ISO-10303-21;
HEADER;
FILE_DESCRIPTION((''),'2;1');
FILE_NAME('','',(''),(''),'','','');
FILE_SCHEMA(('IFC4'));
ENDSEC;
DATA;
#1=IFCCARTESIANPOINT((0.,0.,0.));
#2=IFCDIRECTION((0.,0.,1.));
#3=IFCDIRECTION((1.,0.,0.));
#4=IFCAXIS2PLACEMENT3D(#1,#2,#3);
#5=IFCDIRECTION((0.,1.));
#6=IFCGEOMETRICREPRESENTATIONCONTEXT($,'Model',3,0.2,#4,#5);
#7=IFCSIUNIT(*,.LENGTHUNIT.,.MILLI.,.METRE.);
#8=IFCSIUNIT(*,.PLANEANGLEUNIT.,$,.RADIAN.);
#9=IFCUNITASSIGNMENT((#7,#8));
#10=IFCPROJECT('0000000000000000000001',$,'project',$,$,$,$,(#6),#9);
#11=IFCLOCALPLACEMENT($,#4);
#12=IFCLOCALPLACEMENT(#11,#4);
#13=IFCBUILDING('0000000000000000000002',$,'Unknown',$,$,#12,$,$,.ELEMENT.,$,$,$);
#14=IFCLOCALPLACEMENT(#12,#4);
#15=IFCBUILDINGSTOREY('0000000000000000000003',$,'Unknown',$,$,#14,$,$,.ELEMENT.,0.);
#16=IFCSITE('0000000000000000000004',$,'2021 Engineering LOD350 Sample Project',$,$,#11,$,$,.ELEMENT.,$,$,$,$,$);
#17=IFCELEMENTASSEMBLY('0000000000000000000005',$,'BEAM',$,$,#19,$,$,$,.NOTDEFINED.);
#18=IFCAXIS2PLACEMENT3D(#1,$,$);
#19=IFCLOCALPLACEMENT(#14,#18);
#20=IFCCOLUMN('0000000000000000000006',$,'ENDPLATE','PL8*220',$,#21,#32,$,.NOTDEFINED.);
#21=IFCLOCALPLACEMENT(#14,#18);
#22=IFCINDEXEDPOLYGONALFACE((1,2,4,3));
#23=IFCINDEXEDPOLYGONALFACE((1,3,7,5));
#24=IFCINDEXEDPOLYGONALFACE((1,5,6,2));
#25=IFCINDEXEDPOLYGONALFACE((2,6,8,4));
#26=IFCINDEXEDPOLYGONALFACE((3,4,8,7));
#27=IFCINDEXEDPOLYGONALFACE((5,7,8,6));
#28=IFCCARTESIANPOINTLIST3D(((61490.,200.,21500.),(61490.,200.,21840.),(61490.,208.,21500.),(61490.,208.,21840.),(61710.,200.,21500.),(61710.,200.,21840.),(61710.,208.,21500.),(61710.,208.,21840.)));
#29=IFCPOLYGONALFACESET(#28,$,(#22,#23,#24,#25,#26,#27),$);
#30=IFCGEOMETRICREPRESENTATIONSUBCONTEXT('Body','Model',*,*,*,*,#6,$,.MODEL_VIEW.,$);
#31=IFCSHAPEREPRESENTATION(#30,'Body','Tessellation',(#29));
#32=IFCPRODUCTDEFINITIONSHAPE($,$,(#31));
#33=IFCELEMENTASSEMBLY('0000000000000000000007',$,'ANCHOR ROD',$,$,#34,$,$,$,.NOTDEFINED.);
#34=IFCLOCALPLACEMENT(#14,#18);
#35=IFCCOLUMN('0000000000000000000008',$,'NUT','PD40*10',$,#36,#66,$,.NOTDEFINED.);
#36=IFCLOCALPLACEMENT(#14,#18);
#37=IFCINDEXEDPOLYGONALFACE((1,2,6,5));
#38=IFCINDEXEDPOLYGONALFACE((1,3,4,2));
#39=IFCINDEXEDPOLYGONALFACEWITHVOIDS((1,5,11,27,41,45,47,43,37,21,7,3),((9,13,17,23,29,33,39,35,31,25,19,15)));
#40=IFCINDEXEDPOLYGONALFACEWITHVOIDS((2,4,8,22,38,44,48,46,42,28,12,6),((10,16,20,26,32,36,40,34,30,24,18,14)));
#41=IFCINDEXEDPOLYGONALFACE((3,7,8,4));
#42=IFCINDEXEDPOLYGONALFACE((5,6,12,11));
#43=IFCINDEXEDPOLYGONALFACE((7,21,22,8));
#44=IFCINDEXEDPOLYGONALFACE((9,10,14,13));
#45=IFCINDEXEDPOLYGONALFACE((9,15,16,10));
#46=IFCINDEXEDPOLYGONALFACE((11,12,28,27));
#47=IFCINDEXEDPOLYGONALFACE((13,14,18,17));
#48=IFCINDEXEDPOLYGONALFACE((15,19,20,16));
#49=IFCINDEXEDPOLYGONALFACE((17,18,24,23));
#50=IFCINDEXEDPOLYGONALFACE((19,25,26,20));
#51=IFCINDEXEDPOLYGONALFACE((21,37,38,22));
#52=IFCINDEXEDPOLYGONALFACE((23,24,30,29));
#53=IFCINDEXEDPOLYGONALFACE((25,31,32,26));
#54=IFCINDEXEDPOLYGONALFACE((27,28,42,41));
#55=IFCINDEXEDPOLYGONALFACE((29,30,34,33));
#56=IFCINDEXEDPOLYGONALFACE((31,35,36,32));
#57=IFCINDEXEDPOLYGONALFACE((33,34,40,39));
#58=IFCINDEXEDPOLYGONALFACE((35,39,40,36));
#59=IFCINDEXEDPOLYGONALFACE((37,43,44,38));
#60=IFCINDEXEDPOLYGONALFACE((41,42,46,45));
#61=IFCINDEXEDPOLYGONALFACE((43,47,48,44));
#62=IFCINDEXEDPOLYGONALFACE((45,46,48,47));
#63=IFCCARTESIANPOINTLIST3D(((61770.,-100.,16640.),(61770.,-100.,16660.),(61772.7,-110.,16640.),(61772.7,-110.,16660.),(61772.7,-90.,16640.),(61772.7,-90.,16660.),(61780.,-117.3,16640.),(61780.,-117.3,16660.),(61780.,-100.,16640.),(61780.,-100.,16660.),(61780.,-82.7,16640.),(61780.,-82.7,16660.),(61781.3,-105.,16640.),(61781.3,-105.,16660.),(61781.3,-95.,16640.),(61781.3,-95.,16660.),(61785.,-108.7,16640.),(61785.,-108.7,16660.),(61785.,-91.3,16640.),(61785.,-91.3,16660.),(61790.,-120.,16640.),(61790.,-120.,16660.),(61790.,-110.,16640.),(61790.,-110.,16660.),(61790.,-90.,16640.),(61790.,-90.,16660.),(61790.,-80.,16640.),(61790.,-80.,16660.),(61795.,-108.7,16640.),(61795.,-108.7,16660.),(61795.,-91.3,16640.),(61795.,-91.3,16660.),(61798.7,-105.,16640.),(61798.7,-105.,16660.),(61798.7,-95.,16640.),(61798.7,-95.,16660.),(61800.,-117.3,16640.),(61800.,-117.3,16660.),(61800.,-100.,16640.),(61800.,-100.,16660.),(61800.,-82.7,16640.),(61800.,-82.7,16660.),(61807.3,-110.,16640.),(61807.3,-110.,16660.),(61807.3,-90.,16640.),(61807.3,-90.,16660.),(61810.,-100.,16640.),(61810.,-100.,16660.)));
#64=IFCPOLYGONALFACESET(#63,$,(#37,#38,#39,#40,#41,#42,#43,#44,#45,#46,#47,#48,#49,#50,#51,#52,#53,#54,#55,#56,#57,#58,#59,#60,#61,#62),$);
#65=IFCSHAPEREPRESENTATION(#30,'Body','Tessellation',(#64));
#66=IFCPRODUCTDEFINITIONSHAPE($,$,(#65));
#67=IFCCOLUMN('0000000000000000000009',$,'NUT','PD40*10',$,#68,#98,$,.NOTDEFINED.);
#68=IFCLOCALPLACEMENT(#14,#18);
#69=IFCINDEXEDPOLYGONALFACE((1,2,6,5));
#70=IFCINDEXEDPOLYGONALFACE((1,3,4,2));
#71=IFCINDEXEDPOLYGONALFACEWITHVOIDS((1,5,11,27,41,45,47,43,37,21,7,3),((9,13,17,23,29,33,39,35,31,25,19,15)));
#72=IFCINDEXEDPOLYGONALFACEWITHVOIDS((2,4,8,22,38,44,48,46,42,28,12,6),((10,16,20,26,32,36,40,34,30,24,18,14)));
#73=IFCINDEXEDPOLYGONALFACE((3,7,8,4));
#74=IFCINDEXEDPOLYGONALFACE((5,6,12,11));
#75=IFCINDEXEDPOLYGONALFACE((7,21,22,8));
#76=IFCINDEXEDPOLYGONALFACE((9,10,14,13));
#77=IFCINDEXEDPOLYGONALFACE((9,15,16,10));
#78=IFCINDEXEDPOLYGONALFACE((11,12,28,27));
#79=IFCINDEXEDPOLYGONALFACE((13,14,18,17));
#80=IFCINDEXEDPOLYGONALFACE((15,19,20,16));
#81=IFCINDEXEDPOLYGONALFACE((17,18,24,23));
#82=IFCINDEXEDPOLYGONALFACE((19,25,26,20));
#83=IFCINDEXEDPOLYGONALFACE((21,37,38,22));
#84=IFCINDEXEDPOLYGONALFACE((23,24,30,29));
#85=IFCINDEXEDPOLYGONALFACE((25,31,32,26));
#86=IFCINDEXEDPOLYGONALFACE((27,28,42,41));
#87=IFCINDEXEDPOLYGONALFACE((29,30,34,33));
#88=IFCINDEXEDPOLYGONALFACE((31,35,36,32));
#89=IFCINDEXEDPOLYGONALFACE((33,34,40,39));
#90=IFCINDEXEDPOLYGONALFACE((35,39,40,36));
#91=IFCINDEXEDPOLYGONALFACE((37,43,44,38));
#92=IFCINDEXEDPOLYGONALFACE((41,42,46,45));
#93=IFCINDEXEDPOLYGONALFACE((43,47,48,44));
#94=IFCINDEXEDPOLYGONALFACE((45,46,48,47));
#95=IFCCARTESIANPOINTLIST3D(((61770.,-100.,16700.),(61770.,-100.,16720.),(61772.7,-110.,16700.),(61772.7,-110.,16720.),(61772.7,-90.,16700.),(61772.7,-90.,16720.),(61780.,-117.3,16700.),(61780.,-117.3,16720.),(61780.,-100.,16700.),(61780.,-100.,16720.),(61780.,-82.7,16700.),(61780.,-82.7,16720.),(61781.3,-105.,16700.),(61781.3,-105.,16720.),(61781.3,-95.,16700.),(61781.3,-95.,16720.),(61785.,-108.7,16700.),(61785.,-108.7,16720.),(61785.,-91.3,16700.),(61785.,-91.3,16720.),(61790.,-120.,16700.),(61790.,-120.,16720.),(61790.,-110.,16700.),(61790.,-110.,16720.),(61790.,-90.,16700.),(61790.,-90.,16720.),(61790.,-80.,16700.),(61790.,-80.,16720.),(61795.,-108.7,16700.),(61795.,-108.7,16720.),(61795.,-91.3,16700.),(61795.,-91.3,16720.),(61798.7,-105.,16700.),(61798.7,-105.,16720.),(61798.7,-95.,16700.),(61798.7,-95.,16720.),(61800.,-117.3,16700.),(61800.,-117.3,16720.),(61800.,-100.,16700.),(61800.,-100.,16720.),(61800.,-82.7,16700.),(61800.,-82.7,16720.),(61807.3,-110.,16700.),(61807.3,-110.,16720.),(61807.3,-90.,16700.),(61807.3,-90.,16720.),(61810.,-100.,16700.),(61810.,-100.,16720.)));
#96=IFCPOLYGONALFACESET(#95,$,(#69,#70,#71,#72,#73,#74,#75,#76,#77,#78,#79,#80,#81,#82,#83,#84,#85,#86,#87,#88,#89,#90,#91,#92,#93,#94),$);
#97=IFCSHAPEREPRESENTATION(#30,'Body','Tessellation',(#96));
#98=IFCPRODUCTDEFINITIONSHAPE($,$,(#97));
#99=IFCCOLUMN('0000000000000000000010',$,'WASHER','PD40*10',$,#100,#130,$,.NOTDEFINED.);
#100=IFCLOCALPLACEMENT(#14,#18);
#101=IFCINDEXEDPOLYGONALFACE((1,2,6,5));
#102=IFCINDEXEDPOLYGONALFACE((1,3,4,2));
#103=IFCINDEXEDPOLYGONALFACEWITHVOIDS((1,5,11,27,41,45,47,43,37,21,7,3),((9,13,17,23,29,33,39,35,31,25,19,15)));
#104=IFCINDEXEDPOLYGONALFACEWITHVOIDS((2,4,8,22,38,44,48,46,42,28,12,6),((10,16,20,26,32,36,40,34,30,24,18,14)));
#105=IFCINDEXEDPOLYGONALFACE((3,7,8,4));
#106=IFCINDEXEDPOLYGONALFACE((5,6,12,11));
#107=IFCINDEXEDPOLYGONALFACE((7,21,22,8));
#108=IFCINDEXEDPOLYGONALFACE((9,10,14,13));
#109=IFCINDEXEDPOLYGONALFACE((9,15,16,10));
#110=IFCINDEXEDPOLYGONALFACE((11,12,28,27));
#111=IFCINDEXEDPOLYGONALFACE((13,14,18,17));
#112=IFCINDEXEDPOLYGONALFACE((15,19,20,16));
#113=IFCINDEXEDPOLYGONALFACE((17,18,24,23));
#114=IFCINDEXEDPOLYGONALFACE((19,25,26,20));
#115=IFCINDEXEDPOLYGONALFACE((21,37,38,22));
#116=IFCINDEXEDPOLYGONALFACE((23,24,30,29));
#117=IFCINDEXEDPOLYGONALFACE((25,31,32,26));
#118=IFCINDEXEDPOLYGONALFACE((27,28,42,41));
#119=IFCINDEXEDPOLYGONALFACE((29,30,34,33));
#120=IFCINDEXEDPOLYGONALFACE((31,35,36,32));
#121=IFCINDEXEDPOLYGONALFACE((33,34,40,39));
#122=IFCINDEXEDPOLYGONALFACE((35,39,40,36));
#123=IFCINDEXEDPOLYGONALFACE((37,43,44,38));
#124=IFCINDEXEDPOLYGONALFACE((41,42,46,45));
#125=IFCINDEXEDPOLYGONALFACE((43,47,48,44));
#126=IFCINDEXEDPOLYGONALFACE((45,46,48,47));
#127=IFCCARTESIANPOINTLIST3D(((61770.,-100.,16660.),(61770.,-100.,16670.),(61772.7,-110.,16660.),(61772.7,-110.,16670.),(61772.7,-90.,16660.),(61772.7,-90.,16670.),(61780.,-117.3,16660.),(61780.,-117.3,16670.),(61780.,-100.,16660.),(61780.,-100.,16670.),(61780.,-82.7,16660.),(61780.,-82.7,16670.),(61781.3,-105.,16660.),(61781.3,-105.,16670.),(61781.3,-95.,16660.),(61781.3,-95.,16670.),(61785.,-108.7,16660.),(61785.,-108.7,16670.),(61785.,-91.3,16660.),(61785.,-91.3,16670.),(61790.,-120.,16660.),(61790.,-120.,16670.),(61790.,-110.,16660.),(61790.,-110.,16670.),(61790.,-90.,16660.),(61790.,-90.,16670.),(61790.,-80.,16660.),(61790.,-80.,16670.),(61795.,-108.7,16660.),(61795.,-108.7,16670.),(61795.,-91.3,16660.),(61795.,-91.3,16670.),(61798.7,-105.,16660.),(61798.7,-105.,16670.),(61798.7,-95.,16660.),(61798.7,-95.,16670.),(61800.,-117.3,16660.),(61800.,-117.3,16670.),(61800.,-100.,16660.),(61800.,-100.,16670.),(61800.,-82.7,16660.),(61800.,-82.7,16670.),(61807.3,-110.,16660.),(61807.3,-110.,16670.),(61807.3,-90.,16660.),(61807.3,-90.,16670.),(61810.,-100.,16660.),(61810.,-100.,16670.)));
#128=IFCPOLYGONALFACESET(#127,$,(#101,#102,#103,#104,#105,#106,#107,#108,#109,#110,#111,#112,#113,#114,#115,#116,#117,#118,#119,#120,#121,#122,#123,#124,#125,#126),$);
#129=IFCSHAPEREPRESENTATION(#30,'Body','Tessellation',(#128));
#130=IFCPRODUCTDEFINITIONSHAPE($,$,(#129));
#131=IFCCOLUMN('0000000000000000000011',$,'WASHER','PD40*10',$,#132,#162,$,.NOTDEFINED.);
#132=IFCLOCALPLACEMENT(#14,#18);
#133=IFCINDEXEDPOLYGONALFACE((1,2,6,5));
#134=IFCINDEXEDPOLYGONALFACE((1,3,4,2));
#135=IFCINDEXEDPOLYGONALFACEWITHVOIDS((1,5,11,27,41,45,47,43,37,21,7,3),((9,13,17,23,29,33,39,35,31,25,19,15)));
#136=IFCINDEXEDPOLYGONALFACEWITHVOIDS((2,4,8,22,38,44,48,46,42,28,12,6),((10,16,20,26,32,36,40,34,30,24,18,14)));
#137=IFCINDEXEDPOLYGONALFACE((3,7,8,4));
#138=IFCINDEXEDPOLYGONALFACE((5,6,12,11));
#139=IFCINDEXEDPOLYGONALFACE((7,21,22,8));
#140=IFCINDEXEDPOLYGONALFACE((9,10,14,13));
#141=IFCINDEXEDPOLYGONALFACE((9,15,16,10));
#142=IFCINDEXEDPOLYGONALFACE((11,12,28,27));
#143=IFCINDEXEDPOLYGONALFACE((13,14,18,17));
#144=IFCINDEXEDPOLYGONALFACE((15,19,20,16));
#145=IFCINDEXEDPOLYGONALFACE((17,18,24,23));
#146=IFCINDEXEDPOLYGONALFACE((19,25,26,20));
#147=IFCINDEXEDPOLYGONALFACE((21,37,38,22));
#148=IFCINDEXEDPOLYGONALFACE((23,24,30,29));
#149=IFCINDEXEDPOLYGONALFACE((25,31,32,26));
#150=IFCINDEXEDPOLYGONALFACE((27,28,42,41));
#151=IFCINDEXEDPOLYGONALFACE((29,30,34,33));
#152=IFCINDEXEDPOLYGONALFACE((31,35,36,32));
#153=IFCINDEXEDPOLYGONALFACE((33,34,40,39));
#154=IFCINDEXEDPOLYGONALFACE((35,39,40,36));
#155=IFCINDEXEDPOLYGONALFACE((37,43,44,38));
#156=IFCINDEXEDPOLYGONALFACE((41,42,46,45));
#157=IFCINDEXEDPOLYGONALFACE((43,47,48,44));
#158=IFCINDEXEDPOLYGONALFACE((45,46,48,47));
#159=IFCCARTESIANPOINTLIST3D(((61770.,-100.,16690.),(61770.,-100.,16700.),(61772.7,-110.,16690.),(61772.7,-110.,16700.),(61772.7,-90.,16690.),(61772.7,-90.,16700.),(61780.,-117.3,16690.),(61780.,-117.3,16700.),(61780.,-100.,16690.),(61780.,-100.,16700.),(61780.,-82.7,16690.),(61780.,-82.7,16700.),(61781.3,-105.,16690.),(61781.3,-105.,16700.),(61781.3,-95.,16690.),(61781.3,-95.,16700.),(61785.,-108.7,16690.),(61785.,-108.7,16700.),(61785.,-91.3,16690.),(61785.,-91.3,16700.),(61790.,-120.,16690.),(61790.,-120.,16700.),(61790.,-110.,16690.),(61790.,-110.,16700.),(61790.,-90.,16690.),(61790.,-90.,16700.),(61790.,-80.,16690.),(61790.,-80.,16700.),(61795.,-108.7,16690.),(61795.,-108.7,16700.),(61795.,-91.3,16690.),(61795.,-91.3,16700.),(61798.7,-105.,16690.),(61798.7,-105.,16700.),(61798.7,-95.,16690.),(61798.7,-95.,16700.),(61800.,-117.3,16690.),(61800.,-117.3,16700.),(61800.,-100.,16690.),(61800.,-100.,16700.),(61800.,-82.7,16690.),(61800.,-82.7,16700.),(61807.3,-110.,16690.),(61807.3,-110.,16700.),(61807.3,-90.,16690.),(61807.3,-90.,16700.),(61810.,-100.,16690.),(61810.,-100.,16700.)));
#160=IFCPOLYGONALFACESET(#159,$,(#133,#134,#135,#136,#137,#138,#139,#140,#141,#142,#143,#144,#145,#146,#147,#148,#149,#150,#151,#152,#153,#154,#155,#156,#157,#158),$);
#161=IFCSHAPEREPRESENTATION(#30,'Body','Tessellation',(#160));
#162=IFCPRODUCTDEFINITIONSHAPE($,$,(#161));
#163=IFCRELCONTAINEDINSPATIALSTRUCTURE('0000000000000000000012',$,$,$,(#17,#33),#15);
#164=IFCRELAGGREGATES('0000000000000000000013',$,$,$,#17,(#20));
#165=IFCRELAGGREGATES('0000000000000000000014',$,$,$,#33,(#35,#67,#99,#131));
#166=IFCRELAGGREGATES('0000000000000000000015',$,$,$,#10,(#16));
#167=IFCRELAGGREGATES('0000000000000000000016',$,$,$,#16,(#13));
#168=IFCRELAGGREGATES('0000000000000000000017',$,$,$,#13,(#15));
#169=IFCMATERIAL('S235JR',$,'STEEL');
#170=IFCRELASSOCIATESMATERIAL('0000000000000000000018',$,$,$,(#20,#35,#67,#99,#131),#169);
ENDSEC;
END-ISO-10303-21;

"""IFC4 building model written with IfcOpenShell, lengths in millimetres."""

from ifc_helpers import new_model, si_unit, direction, frame, origin_with_axes, place, context, subcontext, project, spatial, line, indexed_curve, outline, extrude, material, element, aggregate, save


model = new_model("IFC4")

# Units and contexts
model_context = context("Model", 3, precision=0.2, world=origin_with_axes(), true_north=direction((0.0, 1.0)))
body_context = subcontext(model_context, "Body", "Model", "MODEL_VIEW")
ifc_project = project(units=[si_unit("LENGTHUNIT", "METRE", prefix="MILLI"), si_unit("PLANEANGLEUNIT", "RADIAN")], contexts=[model_context])

# Site, building, storey
site_placement = place(None, origin_with_axes())
site = spatial("IfcSite", under=ifc_project, at=site_placement, Name="2021 Engineering LOD350 Sample Project", CompositionType="ELEMENT")
building_placement = place(site_placement, origin_with_axes())
building = spatial("IfcBuilding", under=site, at=building_placement, Name="Unknown", CompositionType="ELEMENT")
storey_placement = place(building_placement, origin_with_axes())
storey = spatial("IfcBuildingStorey", under=building, at=storey_placement, Name="Unknown", CompositionType="ELEMENT", Elevation=0.0)

# Element assembly, column
ifc_material_1 = material(Name="S235JR", Category="STEEL")
assembly_1_placement = place(storey_placement, frame((61600.0, 0.0, 21670.0), z_axis=(1.0, 0.0, 0.0), x_axis=(0.0, 1.0, 0.0)))
assembly_1 = element("IfcElementAssembly", 1, at=assembly_1_placement, inside=storey, Name="BEAM", PredefinedType="NOTDEFINED")
column_1_placement = place(assembly_1_placement, frame((204.0, -170.0, 0.0), z_axis=(1.0, 0.0, 0.0), x_axis=(0.0, 1.0, 0.0)))
column_1 = element("IfcColumn", 2, at=column_1_placement, material=ifc_material_1, Name="ENDPLATE", Description="PL8*220", PredefinedType="NOTDEFINED", context=body_context, shape_type="SolidModel", body=[
    extrude(outline(indexed_curve([(-4.0, -110.0), (4.0, -110.0), (4.0, 110.0), (-4.0, 110.0)], segments=[line(1, 2, 3, 4, 1)])), frame((0.0, 0.0, 0.0), z_axis=(-1.0, 0.0, 0.0), x_axis=(0.0, 0.0, 1.0)), (0.0, 0.0, -1.0), 340.0),
])

# Element assembly, columns
assembly_2_placement = place(storey_placement, frame((61790.0, 100.0, 16730.0), z_axis=(1.0, 0.0, 0.0), x_axis=(0.0, 0.0, -1.0)))
assembly_2 = element("IfcElementAssembly", 3, at=assembly_2_placement, inside=storey, Name="ANCHOR ROD", PredefinedType="NOTDEFINED")
column_2_placement = place(assembly_2_placement, frame((70.0, -200.0, 0.0), z_axis=(0.0, 0.0, 1.0), x_axis=(1.0, 0.0, 0.0)))
column_2 = element("IfcColumn", 4, at=column_2_placement, material=ifc_material_1, Name="NUT", Description="PD40*10", PredefinedType="NOTDEFINED", context=body_context, shape_type="SolidModel", body=[
    extrude(outline(indexed_curve([(20.0, 0.0), (17.3, 10.0), (10.0, 17.3), (0.0, 20.0), (-10.0, 17.3), (-17.3, 10.0), (-20.0, 0.0), (-17.3, -10.0), (-10.0, -17.3), (0.0, -20.0), (10.0, -17.3), (17.3, -10.0)], segments=[line(1, 2, 3, 4, 5, 6, 7, 8, 9, 10, 11, 12, 1)]), holes=[indexed_curve([(10.0, 0.0), (8.7, -5.0), (5.0, -8.7), (0.0, -10.0), (-5.0, -8.7), (-8.7, -5.0), (-10.0, 0.0), (-8.7, 5.0), (-5.0, 8.7), (0.0, 10.0), (5.0, 8.7), (8.7, 5.0)], segments=[line(1, 2, 3, 4, 5, 6, 7, 8, 9, 10, 11, 12, 1)])]), frame((0.0, 0.0, 0.0), z_axis=(-1.0, 0.0, 0.0), x_axis=(0.0, 0.0, 1.0)), (0.0, 0.0, -1.0), 20.0),
])
column_3_placement = place(assembly_2_placement, frame((10.0, -200.0, 0.0), z_axis=(0.0, 0.0, 1.0), x_axis=(1.0, 0.0, 0.0)))
column_3 = element("IfcColumn", 5, at=column_3_placement, material=ifc_material_1, Name="NUT", Description="PD40*10", PredefinedType="NOTDEFINED", context=body_context, shape_type="SolidModel", body=[
    extrude(outline(indexed_curve([(20.0, 0.0), (17.3, 10.0), (10.0, 17.3), (0.0, 20.0), (-10.0, 17.3), (-17.3, 10.0), (-20.0, 0.0), (-17.3, -10.0), (-10.0, -17.3), (0.0, -20.0), (10.0, -17.3), (17.3, -10.0)], segments=[line(1, 2, 3, 4, 5, 6, 7, 8, 9, 10, 11, 12, 1)]), holes=[indexed_curve([(10.0, 0.0), (8.7, -5.0), (5.0, -8.7), (0.0, -10.0), (-5.0, -8.7), (-8.7, -5.0), (-10.0, 0.0), (-8.7, 5.0), (-5.0, 8.7), (0.0, 10.0), (5.0, 8.7), (8.7, 5.0)], segments=[line(1, 2, 3, 4, 5, 6, 7, 8, 9, 10, 11, 12, 1)])]), frame((0.0, 0.0, 0.0), z_axis=(-1.0, 0.0, 0.0), x_axis=(0.0, 0.0, 1.0)), (0.0, 0.0, -1.0), 20.0),
])
column_4_placement = place(assembly_2_placement, frame((60.0, -200.0, 0.0), z_axis=(0.0, 0.0, 1.0), x_axis=(1.0, 0.0, 0.0)))
column_4 = element("IfcColumn", 6, at=column_4_placement, material=ifc_material_1, Name="WASHER", Description="PD40*10", PredefinedType="NOTDEFINED", context=body_context, shape_type="SolidModel", body=[
    extrude(outline(indexed_curve([(20.0, 0.0), (17.3, 10.0), (10.0, 17.3), (0.0, 20.0), (-10.0, 17.3), (-17.3, 10.0), (-20.0, 0.0), (-17.3, -10.0), (-10.0, -17.3), (0.0, -20.0), (10.0, -17.3), (17.3, -10.0)], segments=[line(1, 2, 3, 4, 5, 6, 7, 8, 9, 10, 11, 12, 1)]), holes=[indexed_curve([(10.0, 0.0), (8.7, -5.0), (5.0, -8.7), (0.0, -10.0), (-5.0, -8.7), (-8.7, -5.0), (-10.0, 0.0), (-8.7, 5.0), (-5.0, 8.7), (0.0, 10.0), (5.0, 8.7), (8.7, 5.0)], segments=[line(1, 2, 3, 4, 5, 6, 7, 8, 9, 10, 11, 12, 1)])]), frame((0.0, 0.0, 0.0), z_axis=(-1.0, 0.0, 0.0), x_axis=(0.0, 0.0, 1.0)), (0.0, 0.0, -1.0), 10.0),
])
column_5_placement = place(assembly_2_placement, frame((30.0, -200.0, 0.0), z_axis=(0.0, 0.0, 1.0), x_axis=(1.0, 0.0, 0.0)))
column_5 = element("IfcColumn", 7, at=column_5_placement, material=ifc_material_1, Name="WASHER", Description="PD40*10", PredefinedType="NOTDEFINED", context=body_context, shape_type="SolidModel", body=[
    extrude(outline(indexed_curve([(20.0, 0.0), (17.3, 10.0), (10.0, 17.3), (0.0, 20.0), (-10.0, 17.3), (-17.3, 10.0), (-20.0, 0.0), (-17.3, -10.0), (-10.0, -17.3), (0.0, -20.0), (10.0, -17.3), (17.3, -10.0)], segments=[line(1, 2, 3, 4, 5, 6, 7, 8, 9, 10, 11, 12, 1)]), holes=[indexed_curve([(10.0, 0.0), (8.7, -5.0), (5.0, -8.7), (0.0, -10.0), (-5.0, -8.7), (-8.7, -5.0), (-10.0, 0.0), (-8.7, 5.0), (-5.0, 8.7), (0.0, 10.0), (5.0, 8.7), (8.7, 5.0)], segments=[line(1, 2, 3, 4, 5, 6, 7, 8, 9, 10, 11, 12, 1)])]), frame((0.0, 0.0, 0.0), z_axis=(-1.0, 0.0, 0.0), x_axis=(0.0, 0.0, 1.0)), (0.0, 0.0, -1.0), 10.0),
])

aggregate(assembly_1, [column_1])

aggregate(assembly_2, [column_2, column_3, column_4, column_5])

save(model, "model.ifc")
